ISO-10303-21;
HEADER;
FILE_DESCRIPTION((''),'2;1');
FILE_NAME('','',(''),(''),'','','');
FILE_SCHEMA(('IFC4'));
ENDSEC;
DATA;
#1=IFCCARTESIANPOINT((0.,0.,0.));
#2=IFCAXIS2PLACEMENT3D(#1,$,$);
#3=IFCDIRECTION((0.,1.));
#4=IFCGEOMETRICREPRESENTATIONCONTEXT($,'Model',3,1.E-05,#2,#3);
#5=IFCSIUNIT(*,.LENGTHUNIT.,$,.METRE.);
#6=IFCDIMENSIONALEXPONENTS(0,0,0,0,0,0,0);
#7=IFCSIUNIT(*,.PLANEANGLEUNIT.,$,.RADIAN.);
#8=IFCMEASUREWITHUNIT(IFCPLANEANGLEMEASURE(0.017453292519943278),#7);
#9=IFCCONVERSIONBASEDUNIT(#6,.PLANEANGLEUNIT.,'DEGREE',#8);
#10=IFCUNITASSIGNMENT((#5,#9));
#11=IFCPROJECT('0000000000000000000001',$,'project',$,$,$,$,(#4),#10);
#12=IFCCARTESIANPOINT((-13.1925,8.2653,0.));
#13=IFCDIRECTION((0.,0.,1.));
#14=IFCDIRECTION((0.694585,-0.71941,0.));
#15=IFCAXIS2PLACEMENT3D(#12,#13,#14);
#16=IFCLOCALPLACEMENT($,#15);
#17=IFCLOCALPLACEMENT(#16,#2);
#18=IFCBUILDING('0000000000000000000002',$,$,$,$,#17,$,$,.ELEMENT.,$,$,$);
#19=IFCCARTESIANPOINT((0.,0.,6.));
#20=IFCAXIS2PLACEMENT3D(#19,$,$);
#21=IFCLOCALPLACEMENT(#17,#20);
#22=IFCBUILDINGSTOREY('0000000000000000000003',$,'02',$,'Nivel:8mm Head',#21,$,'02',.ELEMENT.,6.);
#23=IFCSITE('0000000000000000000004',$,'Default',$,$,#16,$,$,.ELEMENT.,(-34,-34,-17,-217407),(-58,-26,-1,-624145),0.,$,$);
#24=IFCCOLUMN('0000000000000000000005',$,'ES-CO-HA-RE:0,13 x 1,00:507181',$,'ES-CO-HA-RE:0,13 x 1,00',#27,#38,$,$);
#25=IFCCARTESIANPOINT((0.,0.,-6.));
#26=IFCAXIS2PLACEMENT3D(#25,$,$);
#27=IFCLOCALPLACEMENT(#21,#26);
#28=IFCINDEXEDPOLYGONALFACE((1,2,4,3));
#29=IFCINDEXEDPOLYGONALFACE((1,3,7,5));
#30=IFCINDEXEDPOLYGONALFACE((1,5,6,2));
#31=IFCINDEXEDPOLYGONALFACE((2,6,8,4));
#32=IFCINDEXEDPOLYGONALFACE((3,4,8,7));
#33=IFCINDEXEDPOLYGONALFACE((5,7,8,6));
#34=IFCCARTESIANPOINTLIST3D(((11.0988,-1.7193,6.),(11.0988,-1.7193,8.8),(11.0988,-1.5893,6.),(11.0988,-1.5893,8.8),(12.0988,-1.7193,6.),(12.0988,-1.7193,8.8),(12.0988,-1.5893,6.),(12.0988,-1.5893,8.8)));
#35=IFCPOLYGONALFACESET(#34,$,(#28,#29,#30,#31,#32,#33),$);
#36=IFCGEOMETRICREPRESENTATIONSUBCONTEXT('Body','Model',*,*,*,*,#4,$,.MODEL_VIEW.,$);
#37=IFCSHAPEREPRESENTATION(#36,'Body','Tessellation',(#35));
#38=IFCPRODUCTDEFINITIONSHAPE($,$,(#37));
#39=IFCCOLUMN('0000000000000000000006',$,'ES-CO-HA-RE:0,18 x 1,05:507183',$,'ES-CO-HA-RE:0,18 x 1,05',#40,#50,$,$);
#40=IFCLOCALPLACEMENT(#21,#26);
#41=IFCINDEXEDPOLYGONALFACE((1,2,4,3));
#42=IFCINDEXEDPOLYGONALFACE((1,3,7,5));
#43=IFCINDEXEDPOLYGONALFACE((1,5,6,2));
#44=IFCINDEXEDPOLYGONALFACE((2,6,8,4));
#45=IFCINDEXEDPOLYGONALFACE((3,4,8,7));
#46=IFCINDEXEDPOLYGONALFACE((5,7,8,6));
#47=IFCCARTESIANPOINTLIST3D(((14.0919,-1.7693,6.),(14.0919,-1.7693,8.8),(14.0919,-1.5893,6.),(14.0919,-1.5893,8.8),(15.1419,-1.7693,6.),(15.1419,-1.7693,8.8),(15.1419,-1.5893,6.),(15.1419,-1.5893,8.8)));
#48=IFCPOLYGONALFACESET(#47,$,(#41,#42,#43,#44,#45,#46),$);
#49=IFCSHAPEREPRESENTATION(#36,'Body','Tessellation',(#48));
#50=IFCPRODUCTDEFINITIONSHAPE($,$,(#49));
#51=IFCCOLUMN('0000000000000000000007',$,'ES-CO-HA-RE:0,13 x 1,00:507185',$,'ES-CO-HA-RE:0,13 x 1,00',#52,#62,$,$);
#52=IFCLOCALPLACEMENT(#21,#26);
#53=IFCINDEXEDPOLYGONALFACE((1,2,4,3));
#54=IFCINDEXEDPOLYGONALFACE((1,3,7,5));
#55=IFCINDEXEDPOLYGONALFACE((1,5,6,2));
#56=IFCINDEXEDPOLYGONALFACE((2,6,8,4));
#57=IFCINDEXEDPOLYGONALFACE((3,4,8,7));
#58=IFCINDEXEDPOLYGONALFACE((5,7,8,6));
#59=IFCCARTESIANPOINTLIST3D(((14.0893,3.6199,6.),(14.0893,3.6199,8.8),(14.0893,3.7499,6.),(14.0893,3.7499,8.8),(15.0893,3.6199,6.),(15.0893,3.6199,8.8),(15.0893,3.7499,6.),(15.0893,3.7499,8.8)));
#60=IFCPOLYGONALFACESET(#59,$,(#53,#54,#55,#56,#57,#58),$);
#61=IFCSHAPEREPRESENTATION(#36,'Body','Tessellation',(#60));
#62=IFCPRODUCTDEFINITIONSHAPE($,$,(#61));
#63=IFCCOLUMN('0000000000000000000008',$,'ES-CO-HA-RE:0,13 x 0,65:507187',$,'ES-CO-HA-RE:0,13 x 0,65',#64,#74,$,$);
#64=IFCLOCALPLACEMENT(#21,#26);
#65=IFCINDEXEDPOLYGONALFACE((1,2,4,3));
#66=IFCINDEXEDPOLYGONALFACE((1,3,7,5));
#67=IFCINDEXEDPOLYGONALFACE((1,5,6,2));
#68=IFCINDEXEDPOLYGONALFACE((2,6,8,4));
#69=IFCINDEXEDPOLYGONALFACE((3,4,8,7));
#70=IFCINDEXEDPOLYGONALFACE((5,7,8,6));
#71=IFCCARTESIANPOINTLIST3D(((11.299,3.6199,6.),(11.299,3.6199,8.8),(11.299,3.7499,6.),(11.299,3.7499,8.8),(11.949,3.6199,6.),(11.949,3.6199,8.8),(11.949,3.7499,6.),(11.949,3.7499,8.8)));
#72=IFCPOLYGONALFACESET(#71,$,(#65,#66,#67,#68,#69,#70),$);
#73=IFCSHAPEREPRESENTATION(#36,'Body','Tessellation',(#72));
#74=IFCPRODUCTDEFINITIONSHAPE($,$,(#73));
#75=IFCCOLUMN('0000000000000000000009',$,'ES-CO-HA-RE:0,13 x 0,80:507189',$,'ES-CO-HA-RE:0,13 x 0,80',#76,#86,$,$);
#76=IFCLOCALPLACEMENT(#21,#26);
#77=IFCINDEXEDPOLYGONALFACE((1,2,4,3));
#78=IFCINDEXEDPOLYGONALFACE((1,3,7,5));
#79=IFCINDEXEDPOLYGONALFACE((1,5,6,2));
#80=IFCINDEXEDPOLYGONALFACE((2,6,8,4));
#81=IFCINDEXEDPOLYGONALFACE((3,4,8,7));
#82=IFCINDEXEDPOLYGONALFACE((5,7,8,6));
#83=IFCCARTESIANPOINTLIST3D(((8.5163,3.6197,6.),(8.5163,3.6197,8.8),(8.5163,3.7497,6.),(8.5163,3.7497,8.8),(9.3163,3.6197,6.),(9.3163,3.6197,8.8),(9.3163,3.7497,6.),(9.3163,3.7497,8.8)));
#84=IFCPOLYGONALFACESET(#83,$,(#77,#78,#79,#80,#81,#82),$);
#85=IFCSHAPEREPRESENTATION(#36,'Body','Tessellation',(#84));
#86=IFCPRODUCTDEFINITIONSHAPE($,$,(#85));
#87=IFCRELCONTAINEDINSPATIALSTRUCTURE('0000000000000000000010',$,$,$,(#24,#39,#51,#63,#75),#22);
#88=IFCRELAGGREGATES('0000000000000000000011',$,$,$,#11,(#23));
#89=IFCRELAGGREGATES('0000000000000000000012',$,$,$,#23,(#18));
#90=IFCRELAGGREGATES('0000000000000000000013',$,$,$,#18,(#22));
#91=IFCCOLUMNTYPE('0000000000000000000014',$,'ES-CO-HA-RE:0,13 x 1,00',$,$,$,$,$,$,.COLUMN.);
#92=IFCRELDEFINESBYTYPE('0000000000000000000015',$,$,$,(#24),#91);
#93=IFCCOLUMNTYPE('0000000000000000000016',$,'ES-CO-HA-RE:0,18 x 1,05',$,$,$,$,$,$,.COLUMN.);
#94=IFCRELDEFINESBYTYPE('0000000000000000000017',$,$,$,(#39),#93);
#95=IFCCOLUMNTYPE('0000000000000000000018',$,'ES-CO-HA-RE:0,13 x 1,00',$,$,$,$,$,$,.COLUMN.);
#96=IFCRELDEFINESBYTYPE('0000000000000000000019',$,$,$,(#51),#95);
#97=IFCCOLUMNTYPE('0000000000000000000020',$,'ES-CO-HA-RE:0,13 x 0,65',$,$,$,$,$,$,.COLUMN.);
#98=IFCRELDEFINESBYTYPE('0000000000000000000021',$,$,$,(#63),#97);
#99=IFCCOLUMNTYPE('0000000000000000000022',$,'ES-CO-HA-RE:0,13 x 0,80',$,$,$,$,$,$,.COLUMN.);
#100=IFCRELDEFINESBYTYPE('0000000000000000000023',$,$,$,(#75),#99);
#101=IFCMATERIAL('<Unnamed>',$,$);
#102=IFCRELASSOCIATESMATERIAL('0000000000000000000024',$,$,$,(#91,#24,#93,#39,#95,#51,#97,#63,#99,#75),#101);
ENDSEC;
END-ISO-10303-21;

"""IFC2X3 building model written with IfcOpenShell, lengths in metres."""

from ifc_helpers import new_model, entity, si_unit, converted_unit, direction, frame, frame_2d, origin, origin_2d_with_axis, place, context, subcontext, project, spatial, rectangle, extrude, source, transform, mapped, material, type_object, type_shapes, element, save


model = new_model("IFC2X3")

# Units and contexts
model_context = context("Model", 3, precision=1e-05, world=origin(), true_north=direction((0.0, 1.0)))
body_context = subcontext(model_context, "Body", "Model", "MODEL_VIEW")
ifc_project = project(units=[si_unit("LENGTHUNIT", "METRE"), converted_unit("PLANEANGLEUNIT", "DEGREE", entity("IfcPlaneAngleMeasure", 0.017453292519943278), si_unit("PLANEANGLEUNIT", "RADIAN"), dimensions=[0, 0, 0, 0, 0, 0, 0])], contexts=[model_context])

# Site, building, storey
site_placement = place(None, frame((-13.1925, 8.2653, 0.0), z_axis=(0.0, 0.0, 1.0), x_axis=(0.694585, -0.71941, 0.0)))
site = spatial("IfcSite", under=ifc_project, at=site_placement, Name="Default", CompositionType="ELEMENT", RefLatitude=(-34, -34, -17, -217407), RefLongitude=(-58, -26, -1, -624145), RefElevation=0.0)
building_placement = place(site_placement, origin())
building = spatial("IfcBuilding", under=site, at=building_placement, CompositionType="ELEMENT")
storey_placement = place(building_placement, frame((0.0, 0.0, 6.0)))
storey = spatial("IfcBuildingStorey", under=building, at=storey_placement, Name="02", ObjectType="Nivel:8mm Head", LongName="02", CompositionType="ELEMENT", Elevation=6.0)

# Columns
ifc_material_1 = material(Name="<Unnamed>")
column_type_1 = type_object("IfcColumnType", Name="ES-CO-HA-RE:0,13 x 1,00", PredefinedType="COLUMN", material=ifc_material_1)
shared_shape_1 = source(origin(), body_context, "Body", "SweptSolid", [
    extrude(rectangle(XDim=1.0, YDim=0.13, at=frame_2d((0.0, 0.0), x_axis=(1.0, 0.0))), frame((11.5988, -1.6543, 6.0), z_axis=(0.0, 0.0, 1.0), x_axis=(-1.0, 0.0, 0.0)), (0.0, 0.0, 1.0), 2.8),
])
type_shapes(column_type_1, [shared_shape_1])
column_1_placement = place(storey_placement, frame((0.0, 0.0, -6.0)))
element("IfcColumn", 1, at=column_1_placement, inside=storey, type_object=column_type_1, material=ifc_material_1, Name="ES-CO-HA-RE:0,13 x 1,00:507181", ObjectType="ES-CO-HA-RE:0,13 x 1,00", context=body_context, shape_type="MappedRepresentation", body=[
    mapped(shared_shape_1, transform((0.0, 0.0, 0.0), scale=1.0)),
])
column_type_2 = type_object("IfcColumnType", Name="ES-CO-HA-RE:0,18 x 1,05", PredefinedType="COLUMN", material=ifc_material_1)
shared_shape_2 = source(origin(), body_context, "Body", "SweptSolid", [
    extrude(rectangle(XDim=1.05, YDim=0.18, at=frame_2d((0.0, 0.0), x_axis=(1.0, 0.0))), frame((14.6169, -1.6793, 6.0), z_axis=(0.0, 0.0, 1.0), x_axis=(-1.0, 0.0, 0.0)), (0.0, 0.0, 1.0), 2.8),
])
type_shapes(column_type_2, [shared_shape_2])
column_2_placement = place(storey_placement, frame((0.0, 0.0, -6.0)))
element("IfcColumn", 2, at=column_2_placement, inside=storey, type_object=column_type_2, material=ifc_material_1, Name="ES-CO-HA-RE:0,18 x 1,05:507183", ObjectType="ES-CO-HA-RE:0,18 x 1,05", context=body_context, shape_type="MappedRepresentation", body=[
    mapped(shared_shape_2, transform((0.0, 0.0, 0.0), scale=1.0)),
])
column_type_3 = type_object("IfcColumnType", Name="ES-CO-HA-RE:0,13 x 1,00", PredefinedType="COLUMN", material=ifc_material_1)
shared_shape_3 = source(origin(), body_context, "Body", "SweptSolid", [
    extrude(rectangle(XDim=1.0, YDim=0.13, at=frame_2d((0.0, 0.0), x_axis=(1.0, 0.0))), frame((14.5893, 3.6849, 6.0), z_axis=(0.0, 0.0, 1.0), x_axis=(-1.0, 0.0, 0.0)), (0.0, 0.0, 1.0), 2.8),
])
type_shapes(column_type_3, [shared_shape_3])
column_3_placement = place(storey_placement, frame((0.0, 0.0, -6.0)))
element("IfcColumn", 3, at=column_3_placement, inside=storey, type_object=column_type_3, material=ifc_material_1, Name="ES-CO-HA-RE:0,13 x 1,00:507185", ObjectType="ES-CO-HA-RE:0,13 x 1,00", context=body_context, shape_type="MappedRepresentation", body=[
    mapped(shared_shape_3, transform((0.0, 0.0, 0.0), scale=1.0)),
])
column_type_4 = type_object("IfcColumnType", Name="ES-CO-HA-RE:0,13 x 0,65", PredefinedType="COLUMN", material=ifc_material_1)
shared_shape_4 = source(origin(), body_context, "Body", "SweptSolid", [
    extrude(rectangle(XDim=0.65, YDim=0.13, at=frame_2d((0.0, 0.0), x_axis=(1.0, 0.0))), frame((11.624, 3.6849, 6.0), z_axis=(0.0, 0.0, 1.0), x_axis=(-1.0, 0.0, 0.0)), (0.0, 0.0, 1.0), 2.8),
])
type_shapes(column_type_4, [shared_shape_4])
column_4_placement = place(storey_placement, frame((0.0, 0.0, -6.0)))
element("IfcColumn", 4, at=column_4_placement, inside=storey, type_object=column_type_4, material=ifc_material_1, Name="ES-CO-HA-RE:0,13 x 0,65:507187", ObjectType="ES-CO-HA-RE:0,13 x 0,65", context=body_context, shape_type="MappedRepresentation", body=[
    mapped(shared_shape_4, transform((0.0, 0.0, 0.0), scale=1.0)),
])
column_type_5 = type_object("IfcColumnType", Name="ES-CO-HA-RE:0,13 x 0,80", PredefinedType="COLUMN", material=ifc_material_1)
shared_shape_5 = source(origin(), body_context, "Body", "SweptSolid", [
    extrude(rectangle(XDim=0.8, YDim=0.13, at=origin_2d_with_axis()), frame((8.9163, 3.6847, 6.0), z_axis=(0.0, 0.0, 1.0), x_axis=(-1.0, 0.0, 0.0)), (0.0, 0.0, 1.0), 2.8),
])
type_shapes(column_type_5, [shared_shape_5])
column_5_placement = place(storey_placement, frame((0.0, 0.0, -6.0)))
element("IfcColumn", 5, at=column_5_placement, inside=storey, type_object=column_type_5, material=ifc_material_1, Name="ES-CO-HA-RE:0,13 x 0,80:507189", ObjectType="ES-CO-HA-RE:0,13 x 0,80", context=body_context, shape_type="MappedRepresentation", body=[
    mapped(shared_shape_5, transform((0.0, 0.0, 0.0), scale=1.0)),
])

save(model, "model.ifc")
